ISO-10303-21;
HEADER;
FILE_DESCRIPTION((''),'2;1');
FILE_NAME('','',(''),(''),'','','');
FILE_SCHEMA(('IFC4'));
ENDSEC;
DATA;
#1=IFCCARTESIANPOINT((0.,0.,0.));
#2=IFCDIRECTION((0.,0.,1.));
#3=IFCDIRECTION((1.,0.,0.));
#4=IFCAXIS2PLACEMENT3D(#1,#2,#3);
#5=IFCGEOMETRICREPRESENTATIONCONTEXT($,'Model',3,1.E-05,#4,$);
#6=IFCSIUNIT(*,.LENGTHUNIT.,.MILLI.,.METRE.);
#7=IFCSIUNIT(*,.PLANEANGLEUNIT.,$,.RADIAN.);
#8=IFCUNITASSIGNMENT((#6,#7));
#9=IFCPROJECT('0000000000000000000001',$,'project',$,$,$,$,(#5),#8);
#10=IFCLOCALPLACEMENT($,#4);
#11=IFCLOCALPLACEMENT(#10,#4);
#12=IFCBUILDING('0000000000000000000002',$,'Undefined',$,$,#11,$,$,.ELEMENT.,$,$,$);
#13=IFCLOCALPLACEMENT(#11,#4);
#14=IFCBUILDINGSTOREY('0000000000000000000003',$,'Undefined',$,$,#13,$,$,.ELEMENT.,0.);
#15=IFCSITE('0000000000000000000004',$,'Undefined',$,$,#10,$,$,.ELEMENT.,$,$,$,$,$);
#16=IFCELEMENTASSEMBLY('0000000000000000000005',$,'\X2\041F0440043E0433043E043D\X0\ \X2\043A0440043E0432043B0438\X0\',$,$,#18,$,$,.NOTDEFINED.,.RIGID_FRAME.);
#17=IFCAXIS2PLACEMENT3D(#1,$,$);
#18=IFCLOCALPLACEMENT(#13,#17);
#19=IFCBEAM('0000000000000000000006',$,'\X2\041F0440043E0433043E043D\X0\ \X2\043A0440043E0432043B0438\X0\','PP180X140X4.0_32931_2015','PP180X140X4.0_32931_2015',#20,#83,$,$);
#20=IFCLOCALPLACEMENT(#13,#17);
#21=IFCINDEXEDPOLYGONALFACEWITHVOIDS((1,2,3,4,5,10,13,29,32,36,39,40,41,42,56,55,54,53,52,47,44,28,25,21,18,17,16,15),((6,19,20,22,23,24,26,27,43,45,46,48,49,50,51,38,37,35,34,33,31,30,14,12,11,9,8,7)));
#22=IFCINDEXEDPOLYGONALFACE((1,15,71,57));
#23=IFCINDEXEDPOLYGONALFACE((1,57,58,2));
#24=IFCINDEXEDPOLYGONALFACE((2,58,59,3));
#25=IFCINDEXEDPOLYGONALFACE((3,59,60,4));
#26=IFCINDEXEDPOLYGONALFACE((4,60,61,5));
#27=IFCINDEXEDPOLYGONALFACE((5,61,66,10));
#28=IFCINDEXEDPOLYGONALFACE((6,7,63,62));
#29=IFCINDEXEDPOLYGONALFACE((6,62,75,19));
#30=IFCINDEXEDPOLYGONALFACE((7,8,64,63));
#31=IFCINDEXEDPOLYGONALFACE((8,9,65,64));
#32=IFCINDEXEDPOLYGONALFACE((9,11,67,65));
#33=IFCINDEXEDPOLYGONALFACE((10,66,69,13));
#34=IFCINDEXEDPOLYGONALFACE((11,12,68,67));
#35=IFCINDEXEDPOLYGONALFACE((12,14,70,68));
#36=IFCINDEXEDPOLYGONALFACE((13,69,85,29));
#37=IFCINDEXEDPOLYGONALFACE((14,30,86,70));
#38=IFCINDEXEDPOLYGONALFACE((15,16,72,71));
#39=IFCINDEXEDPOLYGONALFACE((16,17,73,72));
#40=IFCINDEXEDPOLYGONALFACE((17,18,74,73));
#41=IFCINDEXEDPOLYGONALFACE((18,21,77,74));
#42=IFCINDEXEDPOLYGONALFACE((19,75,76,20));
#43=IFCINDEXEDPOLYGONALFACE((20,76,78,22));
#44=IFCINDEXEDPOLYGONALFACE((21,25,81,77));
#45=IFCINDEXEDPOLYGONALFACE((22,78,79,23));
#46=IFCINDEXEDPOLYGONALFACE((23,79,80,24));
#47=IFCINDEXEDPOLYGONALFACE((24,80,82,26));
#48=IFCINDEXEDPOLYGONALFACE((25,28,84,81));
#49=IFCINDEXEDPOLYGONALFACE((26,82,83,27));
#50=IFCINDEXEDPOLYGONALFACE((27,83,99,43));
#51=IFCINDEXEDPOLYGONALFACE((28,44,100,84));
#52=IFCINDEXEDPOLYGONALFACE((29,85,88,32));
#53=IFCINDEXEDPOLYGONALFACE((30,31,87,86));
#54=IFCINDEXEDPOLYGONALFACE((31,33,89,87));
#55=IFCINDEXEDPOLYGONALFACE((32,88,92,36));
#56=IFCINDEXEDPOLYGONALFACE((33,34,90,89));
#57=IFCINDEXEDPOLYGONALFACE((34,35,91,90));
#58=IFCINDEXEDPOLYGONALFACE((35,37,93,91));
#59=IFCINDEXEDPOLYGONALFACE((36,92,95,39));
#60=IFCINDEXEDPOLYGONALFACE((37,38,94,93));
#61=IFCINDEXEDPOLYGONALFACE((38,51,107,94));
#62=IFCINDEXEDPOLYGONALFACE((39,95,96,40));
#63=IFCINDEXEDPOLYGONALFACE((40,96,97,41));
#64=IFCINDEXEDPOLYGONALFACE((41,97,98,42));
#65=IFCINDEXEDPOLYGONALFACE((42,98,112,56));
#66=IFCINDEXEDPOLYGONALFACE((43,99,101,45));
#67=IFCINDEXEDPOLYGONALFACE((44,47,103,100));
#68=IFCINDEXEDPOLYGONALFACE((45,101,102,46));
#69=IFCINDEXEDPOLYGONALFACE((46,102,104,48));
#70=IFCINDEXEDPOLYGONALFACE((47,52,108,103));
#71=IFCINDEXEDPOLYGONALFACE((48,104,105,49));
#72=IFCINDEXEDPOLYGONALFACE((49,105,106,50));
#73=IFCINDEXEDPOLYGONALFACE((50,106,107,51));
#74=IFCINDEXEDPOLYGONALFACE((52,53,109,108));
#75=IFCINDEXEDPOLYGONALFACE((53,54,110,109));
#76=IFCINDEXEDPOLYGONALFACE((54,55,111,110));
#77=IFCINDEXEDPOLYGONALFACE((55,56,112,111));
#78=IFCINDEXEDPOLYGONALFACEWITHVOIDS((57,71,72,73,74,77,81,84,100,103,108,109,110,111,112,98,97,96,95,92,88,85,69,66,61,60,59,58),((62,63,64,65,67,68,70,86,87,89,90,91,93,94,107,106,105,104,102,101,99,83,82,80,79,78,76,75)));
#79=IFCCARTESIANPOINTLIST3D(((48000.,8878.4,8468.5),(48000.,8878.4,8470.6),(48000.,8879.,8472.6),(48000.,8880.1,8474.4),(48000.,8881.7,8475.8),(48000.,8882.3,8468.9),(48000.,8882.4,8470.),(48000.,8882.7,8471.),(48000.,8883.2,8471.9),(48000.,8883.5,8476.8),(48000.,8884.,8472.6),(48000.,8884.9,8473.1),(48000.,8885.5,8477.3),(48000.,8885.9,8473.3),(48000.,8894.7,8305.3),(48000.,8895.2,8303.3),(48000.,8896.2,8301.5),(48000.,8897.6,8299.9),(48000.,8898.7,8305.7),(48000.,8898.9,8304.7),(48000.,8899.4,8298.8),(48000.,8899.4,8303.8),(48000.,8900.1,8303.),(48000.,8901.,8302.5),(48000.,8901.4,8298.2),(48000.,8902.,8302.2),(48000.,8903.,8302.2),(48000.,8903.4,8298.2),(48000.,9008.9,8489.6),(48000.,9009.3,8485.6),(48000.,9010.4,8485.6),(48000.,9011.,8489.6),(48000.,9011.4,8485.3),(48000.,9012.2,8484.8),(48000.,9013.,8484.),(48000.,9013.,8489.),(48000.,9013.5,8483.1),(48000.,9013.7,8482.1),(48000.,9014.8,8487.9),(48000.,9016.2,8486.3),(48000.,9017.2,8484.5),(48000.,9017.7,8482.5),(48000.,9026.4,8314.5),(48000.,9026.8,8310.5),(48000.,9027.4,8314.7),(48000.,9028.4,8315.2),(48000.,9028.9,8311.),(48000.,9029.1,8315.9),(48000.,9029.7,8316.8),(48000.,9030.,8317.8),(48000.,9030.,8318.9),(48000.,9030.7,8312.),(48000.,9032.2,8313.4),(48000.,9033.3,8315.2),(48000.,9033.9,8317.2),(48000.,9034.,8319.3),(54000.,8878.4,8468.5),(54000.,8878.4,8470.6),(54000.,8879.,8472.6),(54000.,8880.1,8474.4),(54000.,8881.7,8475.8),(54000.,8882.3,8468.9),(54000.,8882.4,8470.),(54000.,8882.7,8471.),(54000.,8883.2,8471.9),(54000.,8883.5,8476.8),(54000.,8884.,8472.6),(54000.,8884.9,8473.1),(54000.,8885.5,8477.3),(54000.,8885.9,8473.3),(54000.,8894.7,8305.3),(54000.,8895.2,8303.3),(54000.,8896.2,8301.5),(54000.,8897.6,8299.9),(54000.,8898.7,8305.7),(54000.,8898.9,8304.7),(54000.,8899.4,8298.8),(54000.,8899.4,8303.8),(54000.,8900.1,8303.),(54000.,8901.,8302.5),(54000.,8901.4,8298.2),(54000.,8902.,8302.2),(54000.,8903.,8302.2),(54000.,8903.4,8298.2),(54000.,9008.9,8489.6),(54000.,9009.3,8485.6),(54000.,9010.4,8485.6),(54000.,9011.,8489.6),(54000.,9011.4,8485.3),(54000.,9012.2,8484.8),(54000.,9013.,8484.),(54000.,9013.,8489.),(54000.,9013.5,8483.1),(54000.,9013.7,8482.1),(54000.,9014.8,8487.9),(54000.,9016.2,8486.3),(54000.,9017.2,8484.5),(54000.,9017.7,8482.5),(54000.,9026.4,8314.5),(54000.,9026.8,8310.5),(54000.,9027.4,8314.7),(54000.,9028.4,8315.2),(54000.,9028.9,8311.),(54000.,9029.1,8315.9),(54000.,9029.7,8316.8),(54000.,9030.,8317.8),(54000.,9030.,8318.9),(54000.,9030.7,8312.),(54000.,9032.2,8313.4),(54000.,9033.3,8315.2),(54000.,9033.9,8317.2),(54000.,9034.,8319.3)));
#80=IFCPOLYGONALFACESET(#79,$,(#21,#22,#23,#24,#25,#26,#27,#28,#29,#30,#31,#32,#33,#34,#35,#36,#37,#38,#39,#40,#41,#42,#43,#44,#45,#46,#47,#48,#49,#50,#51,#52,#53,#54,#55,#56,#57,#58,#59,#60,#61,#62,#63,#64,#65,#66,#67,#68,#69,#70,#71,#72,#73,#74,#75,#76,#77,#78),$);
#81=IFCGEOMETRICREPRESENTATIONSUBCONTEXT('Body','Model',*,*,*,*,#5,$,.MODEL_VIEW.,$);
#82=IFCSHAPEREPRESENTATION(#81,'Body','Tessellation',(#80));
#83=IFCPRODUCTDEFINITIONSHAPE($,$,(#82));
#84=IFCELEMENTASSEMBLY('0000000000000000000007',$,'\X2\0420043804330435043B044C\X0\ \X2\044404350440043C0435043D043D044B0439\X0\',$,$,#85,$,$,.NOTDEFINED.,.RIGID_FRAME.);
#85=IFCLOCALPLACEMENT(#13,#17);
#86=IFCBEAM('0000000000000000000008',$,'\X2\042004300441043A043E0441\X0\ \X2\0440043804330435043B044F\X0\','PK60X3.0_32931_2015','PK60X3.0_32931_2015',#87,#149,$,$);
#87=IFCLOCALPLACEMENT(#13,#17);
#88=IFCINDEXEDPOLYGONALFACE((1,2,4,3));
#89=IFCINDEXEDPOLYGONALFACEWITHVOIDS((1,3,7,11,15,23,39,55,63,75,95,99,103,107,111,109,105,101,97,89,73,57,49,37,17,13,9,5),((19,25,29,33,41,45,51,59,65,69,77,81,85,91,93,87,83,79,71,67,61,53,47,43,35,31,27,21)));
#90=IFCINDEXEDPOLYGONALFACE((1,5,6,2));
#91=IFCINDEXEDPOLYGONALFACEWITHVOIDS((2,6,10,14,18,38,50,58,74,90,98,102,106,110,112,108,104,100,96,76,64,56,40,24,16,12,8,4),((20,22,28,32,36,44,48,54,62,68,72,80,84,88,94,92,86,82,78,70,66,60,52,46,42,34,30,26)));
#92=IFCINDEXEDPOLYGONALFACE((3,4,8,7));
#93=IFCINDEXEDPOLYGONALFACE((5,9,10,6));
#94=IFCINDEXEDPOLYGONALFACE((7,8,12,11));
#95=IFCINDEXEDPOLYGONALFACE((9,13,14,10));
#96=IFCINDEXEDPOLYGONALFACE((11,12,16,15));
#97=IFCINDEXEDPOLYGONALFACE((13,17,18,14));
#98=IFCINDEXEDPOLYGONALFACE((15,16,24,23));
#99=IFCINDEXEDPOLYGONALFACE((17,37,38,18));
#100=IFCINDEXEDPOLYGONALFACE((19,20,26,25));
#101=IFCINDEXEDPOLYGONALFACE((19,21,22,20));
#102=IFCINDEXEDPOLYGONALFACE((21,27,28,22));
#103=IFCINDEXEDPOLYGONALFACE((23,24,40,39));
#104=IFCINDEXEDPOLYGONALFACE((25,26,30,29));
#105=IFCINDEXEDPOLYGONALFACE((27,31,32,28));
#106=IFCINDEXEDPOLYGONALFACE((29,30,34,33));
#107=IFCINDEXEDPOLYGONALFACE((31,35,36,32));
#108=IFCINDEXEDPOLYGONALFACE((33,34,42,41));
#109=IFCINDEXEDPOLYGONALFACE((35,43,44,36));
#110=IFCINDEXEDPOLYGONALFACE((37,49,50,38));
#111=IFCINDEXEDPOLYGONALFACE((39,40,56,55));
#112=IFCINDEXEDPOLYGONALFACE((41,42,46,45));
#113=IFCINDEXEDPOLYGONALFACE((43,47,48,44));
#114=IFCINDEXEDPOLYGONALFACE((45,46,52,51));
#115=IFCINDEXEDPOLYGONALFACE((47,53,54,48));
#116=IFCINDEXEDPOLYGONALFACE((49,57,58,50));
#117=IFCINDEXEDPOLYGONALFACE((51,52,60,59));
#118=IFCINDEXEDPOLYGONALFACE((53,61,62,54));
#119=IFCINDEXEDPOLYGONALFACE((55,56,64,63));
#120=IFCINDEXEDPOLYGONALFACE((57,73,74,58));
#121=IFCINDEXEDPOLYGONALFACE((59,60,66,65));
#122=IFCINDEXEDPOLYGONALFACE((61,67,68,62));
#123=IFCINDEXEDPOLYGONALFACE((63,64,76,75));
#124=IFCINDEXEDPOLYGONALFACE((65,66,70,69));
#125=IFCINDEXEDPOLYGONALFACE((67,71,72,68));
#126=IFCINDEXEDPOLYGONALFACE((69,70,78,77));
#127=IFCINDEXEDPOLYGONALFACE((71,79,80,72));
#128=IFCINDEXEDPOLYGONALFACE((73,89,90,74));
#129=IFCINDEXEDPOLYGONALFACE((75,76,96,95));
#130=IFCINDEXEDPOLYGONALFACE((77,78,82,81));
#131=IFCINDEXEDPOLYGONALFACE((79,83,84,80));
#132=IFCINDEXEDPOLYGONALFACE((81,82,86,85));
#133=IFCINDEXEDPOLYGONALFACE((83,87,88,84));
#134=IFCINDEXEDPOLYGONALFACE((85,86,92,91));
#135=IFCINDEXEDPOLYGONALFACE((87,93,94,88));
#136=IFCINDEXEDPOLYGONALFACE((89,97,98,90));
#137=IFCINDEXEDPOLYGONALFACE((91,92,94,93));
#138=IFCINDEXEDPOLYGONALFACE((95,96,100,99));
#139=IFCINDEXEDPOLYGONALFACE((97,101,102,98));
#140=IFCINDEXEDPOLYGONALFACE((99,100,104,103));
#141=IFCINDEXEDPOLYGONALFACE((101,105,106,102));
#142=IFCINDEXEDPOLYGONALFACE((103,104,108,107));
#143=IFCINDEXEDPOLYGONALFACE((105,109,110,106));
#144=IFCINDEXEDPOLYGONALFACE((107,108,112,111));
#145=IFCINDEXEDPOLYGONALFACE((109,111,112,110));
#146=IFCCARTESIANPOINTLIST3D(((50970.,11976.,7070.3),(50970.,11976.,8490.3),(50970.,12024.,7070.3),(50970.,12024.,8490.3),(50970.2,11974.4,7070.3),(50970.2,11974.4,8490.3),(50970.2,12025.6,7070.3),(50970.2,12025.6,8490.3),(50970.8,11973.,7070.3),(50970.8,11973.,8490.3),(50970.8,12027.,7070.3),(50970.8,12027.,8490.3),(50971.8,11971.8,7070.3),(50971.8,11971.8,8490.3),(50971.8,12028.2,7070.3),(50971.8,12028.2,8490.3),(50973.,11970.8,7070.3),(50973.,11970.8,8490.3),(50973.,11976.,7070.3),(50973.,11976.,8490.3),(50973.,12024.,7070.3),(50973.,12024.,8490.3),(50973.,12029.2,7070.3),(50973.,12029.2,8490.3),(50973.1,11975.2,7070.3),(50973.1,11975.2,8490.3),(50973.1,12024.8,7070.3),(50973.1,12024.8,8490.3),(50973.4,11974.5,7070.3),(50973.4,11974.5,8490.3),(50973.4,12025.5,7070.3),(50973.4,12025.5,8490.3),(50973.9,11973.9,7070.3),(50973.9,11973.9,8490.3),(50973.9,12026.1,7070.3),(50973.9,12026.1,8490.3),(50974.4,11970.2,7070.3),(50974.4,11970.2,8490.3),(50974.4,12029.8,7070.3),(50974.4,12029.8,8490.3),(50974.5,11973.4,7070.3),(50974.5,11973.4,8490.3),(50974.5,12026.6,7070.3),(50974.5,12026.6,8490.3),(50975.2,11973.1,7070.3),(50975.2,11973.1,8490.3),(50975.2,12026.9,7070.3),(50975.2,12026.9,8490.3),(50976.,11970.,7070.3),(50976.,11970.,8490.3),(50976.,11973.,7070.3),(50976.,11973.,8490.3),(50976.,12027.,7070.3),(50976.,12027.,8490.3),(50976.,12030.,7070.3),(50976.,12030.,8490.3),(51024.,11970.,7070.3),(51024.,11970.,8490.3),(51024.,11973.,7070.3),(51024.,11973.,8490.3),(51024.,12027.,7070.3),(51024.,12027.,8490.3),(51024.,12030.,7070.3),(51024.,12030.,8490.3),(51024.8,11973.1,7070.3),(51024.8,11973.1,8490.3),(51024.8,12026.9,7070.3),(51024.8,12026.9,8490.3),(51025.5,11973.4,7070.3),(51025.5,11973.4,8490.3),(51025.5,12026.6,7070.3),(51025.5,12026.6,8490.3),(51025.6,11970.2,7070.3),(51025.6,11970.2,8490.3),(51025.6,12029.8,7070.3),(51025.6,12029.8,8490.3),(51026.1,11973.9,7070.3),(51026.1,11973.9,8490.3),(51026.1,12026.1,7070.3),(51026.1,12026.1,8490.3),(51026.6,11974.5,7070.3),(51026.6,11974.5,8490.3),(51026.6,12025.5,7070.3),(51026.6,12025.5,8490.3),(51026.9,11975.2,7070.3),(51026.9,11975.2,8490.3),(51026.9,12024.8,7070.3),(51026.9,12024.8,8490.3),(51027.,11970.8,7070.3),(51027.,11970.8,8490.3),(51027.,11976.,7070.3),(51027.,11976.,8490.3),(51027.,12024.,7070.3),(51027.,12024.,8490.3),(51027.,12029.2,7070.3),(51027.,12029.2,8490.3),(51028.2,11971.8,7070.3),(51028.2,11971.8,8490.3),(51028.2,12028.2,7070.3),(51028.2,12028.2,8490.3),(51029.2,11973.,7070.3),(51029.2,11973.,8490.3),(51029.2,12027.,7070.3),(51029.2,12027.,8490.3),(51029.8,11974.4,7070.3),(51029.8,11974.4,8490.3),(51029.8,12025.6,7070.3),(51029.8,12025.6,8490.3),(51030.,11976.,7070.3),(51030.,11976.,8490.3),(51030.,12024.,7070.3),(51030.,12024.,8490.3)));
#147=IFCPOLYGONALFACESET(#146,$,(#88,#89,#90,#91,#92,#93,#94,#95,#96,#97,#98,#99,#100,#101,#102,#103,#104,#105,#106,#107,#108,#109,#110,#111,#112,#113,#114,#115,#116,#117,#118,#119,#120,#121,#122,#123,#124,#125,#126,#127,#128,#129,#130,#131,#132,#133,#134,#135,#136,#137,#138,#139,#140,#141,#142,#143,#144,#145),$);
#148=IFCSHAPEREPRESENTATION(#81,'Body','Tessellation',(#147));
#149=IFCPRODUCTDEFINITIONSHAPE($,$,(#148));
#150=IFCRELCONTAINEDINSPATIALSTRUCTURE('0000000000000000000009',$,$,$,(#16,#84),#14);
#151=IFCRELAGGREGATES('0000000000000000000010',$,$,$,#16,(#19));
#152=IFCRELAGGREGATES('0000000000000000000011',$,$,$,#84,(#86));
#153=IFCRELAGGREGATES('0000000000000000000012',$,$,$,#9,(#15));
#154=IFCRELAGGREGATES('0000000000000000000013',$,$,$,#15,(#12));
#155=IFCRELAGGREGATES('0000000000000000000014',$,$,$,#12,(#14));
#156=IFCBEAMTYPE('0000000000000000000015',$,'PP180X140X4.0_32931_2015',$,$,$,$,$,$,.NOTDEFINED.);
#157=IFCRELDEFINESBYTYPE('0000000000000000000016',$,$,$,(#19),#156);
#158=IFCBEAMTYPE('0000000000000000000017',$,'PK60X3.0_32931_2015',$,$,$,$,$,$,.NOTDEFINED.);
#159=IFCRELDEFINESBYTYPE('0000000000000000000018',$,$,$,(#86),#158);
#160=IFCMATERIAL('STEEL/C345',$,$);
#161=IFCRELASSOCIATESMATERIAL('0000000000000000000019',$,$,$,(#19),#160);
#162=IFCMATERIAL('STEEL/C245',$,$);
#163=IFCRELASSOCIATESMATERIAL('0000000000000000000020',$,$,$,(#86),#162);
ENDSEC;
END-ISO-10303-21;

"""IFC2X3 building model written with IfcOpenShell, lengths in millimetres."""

from ifc_helpers import new_model, si_unit, frame, origin_with_axes, origin_2d_with_axis, place, context, subcontext, project, spatial, hollow_rectangle, extrude, material, type_object, element, aggregate, save


model = new_model("IFC2X3")

# Units and contexts
model_context = context("Model", 3, precision=1e-05, world=origin_with_axes())
body_context = subcontext(model_context, "Body", "Model", "MODEL_VIEW")
ifc_project = project(units=[si_unit("LENGTHUNIT", "METRE", prefix="MILLI"), si_unit("PLANEANGLEUNIT", "RADIAN")], contexts=[model_context])

# Site, building, storey
site_placement = place(None, origin_with_axes())
site = spatial("IfcSite", under=ifc_project, at=site_placement, Name="Undefined", CompositionType="ELEMENT")
building_placement = place(site_placement, origin_with_axes())
building = spatial("IfcBuilding", under=site, at=building_placement, Name="Undefined", CompositionType="ELEMENT")
storey_placement = place(building_placement, origin_with_axes())
storey = spatial("IfcBuildingStorey", under=building, at=storey_placement, Name="Undefined", CompositionType="ELEMENT", Elevation=0.0)

# Element assembly, beam
ifc_material_1 = material(Name="STEEL/C245")
ifc_material_2 = material(Name="STEEL/C345")
beam_type_1 = type_object("IfcBeamType", Name="PP180X140X4.0_32931_2015", PredefinedType="NOTDEFINED")
assembly_1_placement = place(storey_placement, origin_with_axes())
assembly_1 = element("IfcElementAssembly", 1, at=assembly_1_placement, inside=storey, Name="Прогон кровли", AssemblyPlace="NOTDEFINED", PredefinedType="RIGID_FRAME")
beam_1_placement = place(assembly_1_placement, frame((48000.0, 8956.2, 8393.9), z_axis=(0.0, -0.099504, 0.995037), x_axis=(1.0, 0.0, 0.0)))
beam_1 = element("IfcBeam", 2, at=beam_1_placement, type_object=beam_type_1, material=ifc_material_2, Name="Прогон кровли", Description="PP180X140X4.0_32931_2015", ObjectType="PP180X140X4.0_32931_2015", context=body_context, shape_type="SweptSolid", body=[
    extrude(hollow_rectangle(XDim=140.0, YDim=180.0, WallThickness=4.0, InnerFilletRadius=4.0, OuterFilletRadius=8.0, at=origin_2d_with_axis()), frame((6000.0, 0.0, 0.0), z_axis=(-1.0, 0.0, 0.0), x_axis=(0.0, -1.0, 0.0)), (0.0, 0.0, 1.0), 6000.0),
])
aggregate(assembly_1, [beam_1])

# Element assembly, beam
assembly_2_placement = place(storey_placement, origin_with_axes())
assembly_2 = element("IfcElementAssembly", 3, at=assembly_2_placement, inside=storey, Name="Ригель ферменный", AssemblyPlace="NOTDEFINED", PredefinedType="RIGID_FRAME")
beam_type_2 = type_object("IfcBeamType", Name="PK60X3.0_32931_2015", PredefinedType="NOTDEFINED")
beam_2_placement = place(assembly_2_placement, frame((51000.0, 12000.0, 8490.3), z_axis=(1.0, 0.0, 0.0), x_axis=(0.0, 0.0, -1.0)))
beam_2 = element("IfcBeam", 4, at=beam_2_placement, type_object=beam_type_2, material=ifc_material_1, Name="Раскос ригеля", Description="PK60X3.0_32931_2015", ObjectType="PK60X3.0_32931_2015", context=body_context, shape_type="SweptSolid", body=[
    extrude(hollow_rectangle(XDim=60.0, YDim=60.0, WallThickness=3.0, InnerFilletRadius=3.0, OuterFilletRadius=6.0, at=origin_2d_with_axis()), frame((1420.0, 0.0, 0.0), z_axis=(-1.0, 0.0, 0.0), x_axis=(0.0, -1.0, 0.0)), (0.0, 0.0, 1.0), 1420.0),
])
aggregate(assembly_2, [beam_2])

save(model, "model.ifc")
